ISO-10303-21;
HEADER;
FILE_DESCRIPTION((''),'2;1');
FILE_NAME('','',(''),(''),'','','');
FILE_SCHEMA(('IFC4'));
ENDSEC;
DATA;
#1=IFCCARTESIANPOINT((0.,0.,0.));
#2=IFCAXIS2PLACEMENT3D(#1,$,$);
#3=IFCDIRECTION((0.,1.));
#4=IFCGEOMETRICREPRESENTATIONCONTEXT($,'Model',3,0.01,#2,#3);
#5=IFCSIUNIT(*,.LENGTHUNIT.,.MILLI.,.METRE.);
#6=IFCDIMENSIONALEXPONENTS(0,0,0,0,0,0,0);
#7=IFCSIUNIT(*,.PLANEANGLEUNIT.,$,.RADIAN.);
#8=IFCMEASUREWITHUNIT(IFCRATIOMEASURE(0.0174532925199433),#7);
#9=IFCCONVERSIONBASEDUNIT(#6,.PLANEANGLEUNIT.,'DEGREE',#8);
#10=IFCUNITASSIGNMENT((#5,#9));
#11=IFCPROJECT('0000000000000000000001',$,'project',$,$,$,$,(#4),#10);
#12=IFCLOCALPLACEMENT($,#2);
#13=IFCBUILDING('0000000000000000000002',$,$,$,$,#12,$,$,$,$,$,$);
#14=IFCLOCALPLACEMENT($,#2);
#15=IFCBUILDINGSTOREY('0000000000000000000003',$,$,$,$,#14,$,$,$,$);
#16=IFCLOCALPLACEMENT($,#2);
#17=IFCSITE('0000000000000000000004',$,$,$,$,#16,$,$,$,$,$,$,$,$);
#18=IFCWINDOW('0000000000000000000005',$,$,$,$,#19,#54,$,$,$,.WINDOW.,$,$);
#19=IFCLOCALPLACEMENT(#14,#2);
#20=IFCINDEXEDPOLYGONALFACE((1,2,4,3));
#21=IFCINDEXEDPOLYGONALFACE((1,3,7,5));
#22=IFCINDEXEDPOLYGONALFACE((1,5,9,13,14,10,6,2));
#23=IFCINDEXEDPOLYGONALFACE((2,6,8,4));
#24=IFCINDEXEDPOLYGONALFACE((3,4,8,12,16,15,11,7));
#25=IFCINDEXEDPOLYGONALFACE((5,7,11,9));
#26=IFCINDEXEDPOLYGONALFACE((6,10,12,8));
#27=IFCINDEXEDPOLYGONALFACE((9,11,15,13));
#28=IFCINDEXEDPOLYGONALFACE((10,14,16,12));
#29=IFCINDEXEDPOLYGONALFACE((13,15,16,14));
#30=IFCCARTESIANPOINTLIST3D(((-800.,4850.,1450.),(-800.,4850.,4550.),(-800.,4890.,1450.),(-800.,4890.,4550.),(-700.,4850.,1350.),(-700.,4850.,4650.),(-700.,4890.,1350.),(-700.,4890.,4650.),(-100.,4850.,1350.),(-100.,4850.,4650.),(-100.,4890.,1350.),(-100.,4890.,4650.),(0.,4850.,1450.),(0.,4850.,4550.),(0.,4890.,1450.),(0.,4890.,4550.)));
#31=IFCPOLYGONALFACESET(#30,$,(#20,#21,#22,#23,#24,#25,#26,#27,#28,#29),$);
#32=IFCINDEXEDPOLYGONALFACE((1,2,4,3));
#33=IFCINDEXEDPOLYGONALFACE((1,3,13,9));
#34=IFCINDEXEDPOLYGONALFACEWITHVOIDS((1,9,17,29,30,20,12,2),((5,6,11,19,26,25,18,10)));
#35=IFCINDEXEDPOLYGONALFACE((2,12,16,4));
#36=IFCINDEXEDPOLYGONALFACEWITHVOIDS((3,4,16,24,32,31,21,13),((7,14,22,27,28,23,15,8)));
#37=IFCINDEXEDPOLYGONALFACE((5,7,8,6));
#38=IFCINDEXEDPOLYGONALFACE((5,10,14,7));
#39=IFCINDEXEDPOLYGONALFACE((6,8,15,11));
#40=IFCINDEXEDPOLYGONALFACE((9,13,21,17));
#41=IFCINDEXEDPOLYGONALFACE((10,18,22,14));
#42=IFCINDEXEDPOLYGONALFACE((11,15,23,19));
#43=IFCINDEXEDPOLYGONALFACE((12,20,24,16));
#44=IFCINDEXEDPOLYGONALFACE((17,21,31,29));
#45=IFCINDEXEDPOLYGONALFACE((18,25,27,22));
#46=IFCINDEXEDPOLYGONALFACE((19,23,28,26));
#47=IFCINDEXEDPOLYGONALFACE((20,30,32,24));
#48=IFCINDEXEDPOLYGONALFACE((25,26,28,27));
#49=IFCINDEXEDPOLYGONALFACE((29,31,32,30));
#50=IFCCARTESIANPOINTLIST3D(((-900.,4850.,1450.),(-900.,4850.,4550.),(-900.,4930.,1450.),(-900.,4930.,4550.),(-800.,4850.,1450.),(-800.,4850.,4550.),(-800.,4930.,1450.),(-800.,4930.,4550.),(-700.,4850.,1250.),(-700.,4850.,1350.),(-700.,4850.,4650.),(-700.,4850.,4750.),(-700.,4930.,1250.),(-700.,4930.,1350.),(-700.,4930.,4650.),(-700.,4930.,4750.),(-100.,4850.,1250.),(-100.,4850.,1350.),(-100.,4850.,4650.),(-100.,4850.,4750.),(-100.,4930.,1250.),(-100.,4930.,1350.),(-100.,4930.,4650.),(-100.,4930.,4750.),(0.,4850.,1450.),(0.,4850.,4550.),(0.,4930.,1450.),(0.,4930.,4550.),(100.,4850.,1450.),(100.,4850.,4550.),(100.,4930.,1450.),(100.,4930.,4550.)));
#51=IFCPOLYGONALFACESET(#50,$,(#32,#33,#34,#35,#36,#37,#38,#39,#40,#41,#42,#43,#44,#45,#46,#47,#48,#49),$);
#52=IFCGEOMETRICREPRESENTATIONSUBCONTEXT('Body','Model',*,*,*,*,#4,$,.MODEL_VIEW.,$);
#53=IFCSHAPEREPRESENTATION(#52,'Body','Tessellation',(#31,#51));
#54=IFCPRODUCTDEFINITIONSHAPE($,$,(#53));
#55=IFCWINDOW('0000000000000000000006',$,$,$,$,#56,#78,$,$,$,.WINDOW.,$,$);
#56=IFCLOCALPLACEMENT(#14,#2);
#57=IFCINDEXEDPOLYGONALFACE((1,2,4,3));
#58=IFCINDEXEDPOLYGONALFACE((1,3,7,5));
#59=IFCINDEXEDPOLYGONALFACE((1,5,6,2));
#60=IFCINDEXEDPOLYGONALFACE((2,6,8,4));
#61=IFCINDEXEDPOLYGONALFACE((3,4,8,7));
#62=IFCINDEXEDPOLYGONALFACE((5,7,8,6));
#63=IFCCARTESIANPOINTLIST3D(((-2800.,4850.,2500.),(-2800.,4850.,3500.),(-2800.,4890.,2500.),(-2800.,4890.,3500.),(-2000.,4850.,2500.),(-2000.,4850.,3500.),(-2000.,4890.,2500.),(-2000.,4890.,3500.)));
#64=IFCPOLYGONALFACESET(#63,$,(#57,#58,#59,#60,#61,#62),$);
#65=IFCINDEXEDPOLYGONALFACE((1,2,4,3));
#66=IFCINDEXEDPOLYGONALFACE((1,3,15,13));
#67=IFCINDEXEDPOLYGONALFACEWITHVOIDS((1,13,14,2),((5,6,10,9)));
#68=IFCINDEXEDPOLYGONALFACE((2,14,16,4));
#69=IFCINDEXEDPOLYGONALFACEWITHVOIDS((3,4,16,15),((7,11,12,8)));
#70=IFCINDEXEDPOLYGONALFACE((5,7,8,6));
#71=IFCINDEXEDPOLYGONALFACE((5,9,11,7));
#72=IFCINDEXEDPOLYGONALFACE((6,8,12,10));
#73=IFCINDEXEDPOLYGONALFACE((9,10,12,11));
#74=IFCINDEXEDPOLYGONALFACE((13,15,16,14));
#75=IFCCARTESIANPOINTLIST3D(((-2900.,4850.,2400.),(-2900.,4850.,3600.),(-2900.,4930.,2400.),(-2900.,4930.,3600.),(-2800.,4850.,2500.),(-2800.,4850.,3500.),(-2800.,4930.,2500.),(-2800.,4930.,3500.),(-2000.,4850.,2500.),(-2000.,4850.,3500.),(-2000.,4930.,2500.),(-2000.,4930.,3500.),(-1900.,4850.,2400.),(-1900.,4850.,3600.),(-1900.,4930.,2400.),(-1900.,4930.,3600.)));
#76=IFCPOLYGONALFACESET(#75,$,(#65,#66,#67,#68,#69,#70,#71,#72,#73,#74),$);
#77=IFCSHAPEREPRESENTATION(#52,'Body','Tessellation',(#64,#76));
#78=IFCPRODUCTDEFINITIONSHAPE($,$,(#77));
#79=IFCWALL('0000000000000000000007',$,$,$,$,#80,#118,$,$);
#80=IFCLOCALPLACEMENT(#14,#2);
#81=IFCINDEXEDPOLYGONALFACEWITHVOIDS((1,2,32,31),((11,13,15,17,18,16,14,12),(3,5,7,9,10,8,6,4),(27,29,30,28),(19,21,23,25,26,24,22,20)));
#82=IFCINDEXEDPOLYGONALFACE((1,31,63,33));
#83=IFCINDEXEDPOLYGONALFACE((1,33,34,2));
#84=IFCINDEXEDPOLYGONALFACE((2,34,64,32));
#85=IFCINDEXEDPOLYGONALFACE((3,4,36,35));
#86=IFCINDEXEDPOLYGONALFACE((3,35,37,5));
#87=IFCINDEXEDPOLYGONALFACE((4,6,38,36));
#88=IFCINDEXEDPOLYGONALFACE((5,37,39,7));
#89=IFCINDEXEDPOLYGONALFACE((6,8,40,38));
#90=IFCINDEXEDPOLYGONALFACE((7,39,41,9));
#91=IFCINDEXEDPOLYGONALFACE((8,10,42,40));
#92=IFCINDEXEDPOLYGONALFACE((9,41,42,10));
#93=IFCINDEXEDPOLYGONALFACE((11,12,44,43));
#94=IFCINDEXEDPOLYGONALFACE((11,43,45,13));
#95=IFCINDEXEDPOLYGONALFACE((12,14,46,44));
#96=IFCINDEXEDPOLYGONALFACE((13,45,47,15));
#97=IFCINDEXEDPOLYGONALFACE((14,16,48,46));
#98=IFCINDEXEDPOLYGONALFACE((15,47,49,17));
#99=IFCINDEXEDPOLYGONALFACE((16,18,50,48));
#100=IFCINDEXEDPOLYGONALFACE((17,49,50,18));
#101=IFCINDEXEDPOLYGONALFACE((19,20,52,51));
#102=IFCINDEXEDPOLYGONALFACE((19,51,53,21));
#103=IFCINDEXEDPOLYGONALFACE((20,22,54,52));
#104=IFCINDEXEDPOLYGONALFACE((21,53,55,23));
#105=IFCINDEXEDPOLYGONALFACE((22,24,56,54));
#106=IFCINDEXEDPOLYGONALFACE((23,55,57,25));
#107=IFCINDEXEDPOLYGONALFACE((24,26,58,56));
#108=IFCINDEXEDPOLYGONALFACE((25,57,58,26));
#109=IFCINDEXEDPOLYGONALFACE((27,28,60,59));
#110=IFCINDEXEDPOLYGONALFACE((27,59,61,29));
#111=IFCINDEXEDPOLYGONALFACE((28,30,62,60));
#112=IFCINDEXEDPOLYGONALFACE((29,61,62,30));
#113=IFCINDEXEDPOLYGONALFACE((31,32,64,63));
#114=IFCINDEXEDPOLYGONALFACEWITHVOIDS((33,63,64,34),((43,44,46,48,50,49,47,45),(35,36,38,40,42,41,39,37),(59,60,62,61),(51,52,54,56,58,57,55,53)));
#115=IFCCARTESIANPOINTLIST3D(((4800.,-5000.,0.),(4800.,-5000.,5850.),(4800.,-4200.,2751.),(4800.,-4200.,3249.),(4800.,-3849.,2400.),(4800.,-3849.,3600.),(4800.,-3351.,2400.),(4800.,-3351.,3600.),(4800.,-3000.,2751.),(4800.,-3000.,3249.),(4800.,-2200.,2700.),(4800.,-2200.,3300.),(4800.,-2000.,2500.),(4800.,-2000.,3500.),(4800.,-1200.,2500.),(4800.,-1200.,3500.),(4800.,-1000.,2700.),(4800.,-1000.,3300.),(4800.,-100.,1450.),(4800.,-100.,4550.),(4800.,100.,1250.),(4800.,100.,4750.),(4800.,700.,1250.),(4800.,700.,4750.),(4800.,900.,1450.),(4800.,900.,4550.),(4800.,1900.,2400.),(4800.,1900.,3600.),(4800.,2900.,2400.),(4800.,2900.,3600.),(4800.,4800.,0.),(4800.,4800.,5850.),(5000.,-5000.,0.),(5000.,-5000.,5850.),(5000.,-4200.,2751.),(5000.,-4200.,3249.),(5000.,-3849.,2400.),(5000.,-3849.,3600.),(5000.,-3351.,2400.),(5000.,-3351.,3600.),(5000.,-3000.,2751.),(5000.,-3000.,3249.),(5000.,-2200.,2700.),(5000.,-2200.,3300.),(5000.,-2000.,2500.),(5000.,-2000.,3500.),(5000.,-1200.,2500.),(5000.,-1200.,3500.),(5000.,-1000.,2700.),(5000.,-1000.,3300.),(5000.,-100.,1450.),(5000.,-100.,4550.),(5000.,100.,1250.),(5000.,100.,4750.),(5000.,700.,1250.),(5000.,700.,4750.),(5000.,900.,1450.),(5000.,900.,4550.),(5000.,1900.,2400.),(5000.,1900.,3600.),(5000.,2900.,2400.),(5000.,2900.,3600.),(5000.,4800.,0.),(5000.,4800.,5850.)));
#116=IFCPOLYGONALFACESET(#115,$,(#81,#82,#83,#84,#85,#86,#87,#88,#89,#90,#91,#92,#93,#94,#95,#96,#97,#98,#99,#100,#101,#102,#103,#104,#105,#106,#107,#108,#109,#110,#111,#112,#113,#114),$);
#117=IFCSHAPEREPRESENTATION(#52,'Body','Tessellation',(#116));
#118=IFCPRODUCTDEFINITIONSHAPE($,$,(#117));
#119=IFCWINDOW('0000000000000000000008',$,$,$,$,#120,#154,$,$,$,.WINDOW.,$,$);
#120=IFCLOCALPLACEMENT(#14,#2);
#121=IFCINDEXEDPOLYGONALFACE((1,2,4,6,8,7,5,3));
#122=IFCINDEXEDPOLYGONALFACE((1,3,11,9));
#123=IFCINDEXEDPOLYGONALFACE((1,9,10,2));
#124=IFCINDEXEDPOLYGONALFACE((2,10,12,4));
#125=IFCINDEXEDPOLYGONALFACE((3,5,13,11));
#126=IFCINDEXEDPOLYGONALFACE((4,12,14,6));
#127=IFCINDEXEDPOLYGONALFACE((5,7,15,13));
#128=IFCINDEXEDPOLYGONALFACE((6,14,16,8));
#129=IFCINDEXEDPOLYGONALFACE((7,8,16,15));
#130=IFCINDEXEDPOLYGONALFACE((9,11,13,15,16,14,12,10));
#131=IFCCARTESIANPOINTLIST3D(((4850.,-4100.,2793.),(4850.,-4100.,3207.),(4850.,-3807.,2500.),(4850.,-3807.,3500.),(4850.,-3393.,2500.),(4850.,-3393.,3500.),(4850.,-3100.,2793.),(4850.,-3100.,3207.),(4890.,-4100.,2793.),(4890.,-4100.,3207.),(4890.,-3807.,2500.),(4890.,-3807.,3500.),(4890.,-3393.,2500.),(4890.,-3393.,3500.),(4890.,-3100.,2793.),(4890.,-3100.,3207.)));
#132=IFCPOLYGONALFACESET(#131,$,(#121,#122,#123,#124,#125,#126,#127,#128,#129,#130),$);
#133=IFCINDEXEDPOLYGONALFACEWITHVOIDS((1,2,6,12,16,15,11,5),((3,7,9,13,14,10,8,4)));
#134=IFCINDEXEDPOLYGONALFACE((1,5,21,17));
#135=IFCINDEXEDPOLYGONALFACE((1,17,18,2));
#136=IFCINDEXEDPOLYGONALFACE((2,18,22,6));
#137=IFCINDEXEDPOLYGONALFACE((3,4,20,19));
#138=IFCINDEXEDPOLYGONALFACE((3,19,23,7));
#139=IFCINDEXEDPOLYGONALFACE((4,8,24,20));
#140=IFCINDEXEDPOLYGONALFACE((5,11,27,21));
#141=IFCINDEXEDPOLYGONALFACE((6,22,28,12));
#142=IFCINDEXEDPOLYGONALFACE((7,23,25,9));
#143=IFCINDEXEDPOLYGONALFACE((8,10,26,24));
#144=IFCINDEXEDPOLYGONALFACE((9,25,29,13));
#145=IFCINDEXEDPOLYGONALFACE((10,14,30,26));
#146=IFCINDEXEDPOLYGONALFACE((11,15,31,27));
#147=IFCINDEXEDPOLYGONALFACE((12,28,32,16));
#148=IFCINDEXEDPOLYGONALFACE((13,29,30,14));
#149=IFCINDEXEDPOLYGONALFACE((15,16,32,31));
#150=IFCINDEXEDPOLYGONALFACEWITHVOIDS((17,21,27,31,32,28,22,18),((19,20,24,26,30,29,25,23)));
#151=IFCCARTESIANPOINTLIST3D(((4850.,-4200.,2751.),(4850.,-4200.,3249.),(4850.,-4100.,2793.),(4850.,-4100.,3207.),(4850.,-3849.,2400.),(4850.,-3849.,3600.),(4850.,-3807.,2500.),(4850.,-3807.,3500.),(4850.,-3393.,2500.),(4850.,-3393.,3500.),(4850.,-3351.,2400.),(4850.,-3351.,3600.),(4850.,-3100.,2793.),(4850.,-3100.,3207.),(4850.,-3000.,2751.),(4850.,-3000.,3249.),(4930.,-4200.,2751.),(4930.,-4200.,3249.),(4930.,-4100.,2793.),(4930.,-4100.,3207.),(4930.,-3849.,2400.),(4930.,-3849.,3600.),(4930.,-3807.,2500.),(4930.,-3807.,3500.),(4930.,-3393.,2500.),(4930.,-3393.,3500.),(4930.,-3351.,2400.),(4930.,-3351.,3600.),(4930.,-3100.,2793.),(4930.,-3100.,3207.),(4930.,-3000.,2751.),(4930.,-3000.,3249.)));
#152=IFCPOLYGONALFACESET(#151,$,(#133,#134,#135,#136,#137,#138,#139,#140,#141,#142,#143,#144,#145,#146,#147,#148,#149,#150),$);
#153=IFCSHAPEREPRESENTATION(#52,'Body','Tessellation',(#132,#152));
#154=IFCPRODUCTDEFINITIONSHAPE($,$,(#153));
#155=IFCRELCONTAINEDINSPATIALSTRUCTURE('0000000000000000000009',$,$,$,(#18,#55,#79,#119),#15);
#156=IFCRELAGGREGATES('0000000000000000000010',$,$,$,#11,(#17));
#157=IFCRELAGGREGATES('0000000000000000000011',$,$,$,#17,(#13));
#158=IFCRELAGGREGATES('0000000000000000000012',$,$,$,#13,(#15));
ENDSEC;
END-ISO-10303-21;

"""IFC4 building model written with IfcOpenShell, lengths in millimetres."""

from ifc_helpers import new_model, entity, si_unit, converted_unit, direction, frame, origin, origin_2d, place, context, subcontext, project, spatial, polyline, rectangle, outline, extrude, element, save


model = new_model("IFC4")

# Units and contexts
model_context = context("Model", 3, precision=0.01, world=origin(), true_north=direction((0.0, 1.0)))
body_context = subcontext(model_context, "Body", "Model", "MODEL_VIEW")
ifc_project = project(units=[si_unit("LENGTHUNIT", "METRE", prefix="MILLI"), converted_unit("PLANEANGLEUNIT", "DEGREE", entity("IfcRatioMeasure", 0.0174532925199433), si_unit("PLANEANGLEUNIT", "RADIAN"), dimensions=[0, 0, 0, 0, 0, 0, 0])], contexts=[model_context])

# Site, building, storey
site_placement = place(None, origin())
site = spatial("IfcSite", under=ifc_project, at=site_placement)
building_placement = place(None, origin())
building = spatial("IfcBuilding", under=site, at=building_placement)
storey_placement = place(None, origin())
storey = spatial("IfcBuildingStorey", under=building, at=storey_placement)

# Shared definitions
wall_1_placement = place(storey_placement, frame((100.0, 4900.0, 0.0), z_axis=(0.0, 0.0, 1.0), x_axis=(-1.0, 0.0, 0.0)))
window_1_placement = place(wall_1_placement, frame((500.0, 50.0, 3000.0)))
window_2_placement = place(wall_1_placement, frame((2500.0, 50.0, 3000.0)))

# Windows
cartesian_point_1 = entity("IfcCartesianPoint", [-500.0, -207.0])
shared_polyline_1 = entity("IfcPolyline", [cartesian_point_1, entity("IfcCartesianPoint", [-500.0, 207.0]), entity("IfcCartesianPoint", [-207.0, 500.0]), entity("IfcCartesianPoint", [207.0, 500.0]), entity("IfcCartesianPoint", [500.0, 207.0]), entity("IfcCartesianPoint", [500.0, -207.0]), entity("IfcCartesianPoint", [207.0, -500.0]), entity("IfcCartesianPoint", [-207.0, -500.0]), cartesian_point_1])
cartesian_point_2 = entity("IfcCartesianPoint", [-400.0, -1550.0])
shared_polyline_2 = entity("IfcPolyline", [cartesian_point_2, entity("IfcCartesianPoint", [-400.0, 1550.0]), entity("IfcCartesianPoint", [-300.0, 1650.0]), entity("IfcCartesianPoint", [300.0, 1650.0]), entity("IfcCartesianPoint", [400.0, 1550.0]), entity("IfcCartesianPoint", [400.0, -1550.0]), entity("IfcCartesianPoint", [300.0, -1650.0]), entity("IfcCartesianPoint", [-300.0, -1650.0]), cartesian_point_2])
cartesian_point_3 = entity("IfcCartesianPoint", [-500.0, -1550.0])
element("IfcWindow", 1, at=window_1_placement, inside=storey, PredefinedType="WINDOW", context=body_context, shape_type="SweptSolid", body=[
    entity("IfcExtrudedAreaSolid", entity("IfcArbitraryClosedProfileDef", "AREA", None, shared_polyline_2), entity("IfcAxis2Placement3D", entity("IfcCartesianPoint", [0.0, 0.0, 0.0]), entity("IfcDirection", [0.0, -1.0, 0.0]), entity("IfcDirection", [1.0, 0.0, 0.0])), entity("IfcDirection", [0.0, 0.0, 1.0]), 40.0),
    entity("IfcExtrudedAreaSolid", entity("IfcArbitraryProfileDefWithVoids", "AREA", None, entity("IfcPolyline", [cartesian_point_3, entity("IfcCartesianPoint", [-500.0, 1550.0]), entity("IfcCartesianPoint", [-300.0, 1750.0]), entity("IfcCartesianPoint", [300.0, 1750.0]), entity("IfcCartesianPoint", [500.0, 1550.0]), entity("IfcCartesianPoint", [500.0, -1550.0]), entity("IfcCartesianPoint", [300.0, -1750.0]), entity("IfcCartesianPoint", [-300.0, -1750.0]), cartesian_point_3]), [shared_polyline_2]), entity("IfcAxis2Placement3D", entity("IfcCartesianPoint", [0.0, 0.0, 0.0]), entity("IfcDirection", [0.0, -1.0, 0.0]), entity("IfcDirection", [1.0, 0.0, 0.0])), entity("IfcDirection", [0.0, 0.0, 1.0]), 80.0),
])
cartesian_point_4 = entity("IfcCartesianPoint", [-400.0, -500.0])
shared_polyline_3 = entity("IfcPolyline", [cartesian_point_4, entity("IfcCartesianPoint", [-400.0, 500.0]), entity("IfcCartesianPoint", [-400.0, 500.0]), entity("IfcCartesianPoint", [400.0, 500.0]), entity("IfcCartesianPoint", [400.0, 500.0]), entity("IfcCartesianPoint", [400.0, -500.0]), entity("IfcCartesianPoint", [400.0, -500.0]), entity("IfcCartesianPoint", [-400.0, -500.0]), cartesian_point_4])
cartesian_point_5 = entity("IfcCartesianPoint", [-500.0, -600.0])
element("IfcWindow", 2, at=window_2_placement, inside=storey, PredefinedType="WINDOW", context=body_context, shape_type="SweptSolid", body=[
    entity("IfcExtrudedAreaSolid", entity("IfcArbitraryClosedProfileDef", "AREA", None, shared_polyline_3), entity("IfcAxis2Placement3D", entity("IfcCartesianPoint", [0.0, 0.0, 0.0]), entity("IfcDirection", [0.0, -1.0, 0.0]), entity("IfcDirection", [1.0, 0.0, 0.0])), entity("IfcDirection", [0.0, 0.0, 1.0]), 40.0),
    entity("IfcExtrudedAreaSolid", entity("IfcArbitraryProfileDefWithVoids", "AREA", None, entity("IfcPolyline", [cartesian_point_5, entity("IfcCartesianPoint", [-500.0, 600.0]), entity("IfcCartesianPoint", [-500.0, 600.0]), entity("IfcCartesianPoint", [500.0, 600.0]), entity("IfcCartesianPoint", [500.0, 600.0]), entity("IfcCartesianPoint", [500.0, -600.0]), entity("IfcCartesianPoint", [500.0, -600.0]), entity("IfcCartesianPoint", [-500.0, -600.0]), cartesian_point_5]), [shared_polyline_3]), entity("IfcAxis2Placement3D", entity("IfcCartesianPoint", [0.0, 0.0, 0.0]), entity("IfcDirection", [0.0, -1.0, 0.0]), entity("IfcDirection", [1.0, 0.0, 0.0])), entity("IfcDirection", [0.0, 0.0, 1.0]), 80.0),
])

# Wall, openings
wall_2_placement = place(storey_placement, frame((4900.0, -100.0, 0.0), z_axis=(0.0, 0.0, 1.0), x_axis=(0.0, 1.0, 0.0)))
wall_2 = element("IfcWall", 3, at=wall_2_placement, inside=storey, context=body_context, shape_type="SweptSolid", body=[
    extrude(rectangle(XDim=9800.0, YDim=200.0, at=origin_2d()), origin(), (0.0, 0.0, 1.0), 5850.0),
])
window_3_placement = place(wall_2_placement, frame((-3500.0, 50.0, 3000.0)))
opening_1_placement = place(window_3_placement, frame((0.0, 50.0, 0.0)))
element("IfcOpeningElement", 4, at=opening_1_placement, cuts=wall_2, context=body_context, shape_type="SweptSolid", body=[
    extrude(outline(polyline([(-600.0, -249.0), (-600.0, 249.0), (-249.0, 600.0), (249.0, 600.0), (600.0, 249.0), (600.0, -249.0), (249.0, -600.0), (-249.0, -600.0), (-600.0, -249.0)])), frame((0.0, 0.0, 0.0), z_axis=(0.0, -1.0, 0.0), x_axis=(1.0, 0.0, 0.0)), (0.0, 0.0, 1.0), 200.0),
])
window_4_placement = place(wall_2_placement, frame((-1500.0, 50.0, 3000.0)))
opening_2_placement = place(window_4_placement, frame((0.0, 50.0, 0.0)))
element("IfcOpeningElement", 5, at=opening_2_placement, cuts=wall_2, context=body_context, shape_type="SweptSolid", body=[
    extrude(outline(polyline([(-600.0, -300.0), (-600.0, 300.0), (-400.0, 500.0), (400.0, 500.0), (600.0, 300.0), (600.0, -300.0), (400.0, -500.0), (-400.0, -500.0), (-600.0, -300.0)])), frame((0.0, 0.0, 0.0), z_axis=(0.0, -1.0, 0.0), x_axis=(1.0, 0.0, 0.0)), (0.0, 0.0, 1.0), 200.0),
])
window_5_placement = place(wall_2_placement, frame((500.0, 50.0, 3000.0)))
opening_3_placement = place(window_5_placement, frame((0.0, 50.0, 0.0)))
element("IfcOpeningElement", 6, at=opening_3_placement, cuts=wall_2, context=body_context, shape_type="SweptSolid", body=[
    extrude(outline(polyline([(-500.0, -1550.0), (-500.0, 1550.0), (-300.0, 1750.0), (300.0, 1750.0), (500.0, 1550.0), (500.0, -1550.0), (300.0, -1750.0), (-300.0, -1750.0), (-500.0, -1550.0)])), frame((0.0, 0.0, 0.0), z_axis=(0.0, -1.0, 0.0), x_axis=(1.0, 0.0, 0.0)), (0.0, 0.0, 1.0), 200.0),
])
window_6_placement = place(wall_2_placement, frame((2500.0, 50.0, 3000.0)))
opening_4_placement = place(window_6_placement, frame((0.0, 50.0, 0.0)))
element("IfcOpeningElement", 7, at=opening_4_placement, cuts=wall_2, context=body_context, shape_type="SweptSolid", body=[
    extrude(outline(polyline([(-500.0, -600.0), (-500.0, 600.0), (-500.0, 600.0), (500.0, 600.0), (500.0, 600.0), (500.0, -600.0), (500.0, -600.0), (-500.0, -600.0), (-500.0, -600.0)])), frame((0.0, 0.0, 0.0), z_axis=(0.0, -1.0, 0.0), x_axis=(1.0, 0.0, 0.0)), (0.0, 0.0, 1.0), 200.0),
])

# Window
cartesian_point_6 = entity("IfcCartesianPoint", [-600.0, -249.0])
element("IfcWindow", 8, at=window_3_placement, inside=storey, PredefinedType="WINDOW", context=body_context, shape_type="SweptSolid", body=[
    entity("IfcExtrudedAreaSolid", entity("IfcArbitraryClosedProfileDef", "AREA", None, shared_polyline_1), entity("IfcAxis2Placement3D", entity("IfcCartesianPoint", [0.0, 0.0, 0.0]), entity("IfcDirection", [0.0, -1.0, 0.0]), entity("IfcDirection", [1.0, 0.0, 0.0])), entity("IfcDirection", [0.0, 0.0, 1.0]), 40.0),
    entity("IfcExtrudedAreaSolid", entity("IfcArbitraryProfileDefWithVoids", "AREA", None, entity("IfcPolyline", [cartesian_point_6, entity("IfcCartesianPoint", [-600.0, 249.0]), entity("IfcCartesianPoint", [-249.0, 600.0]), entity("IfcCartesianPoint", [249.0, 600.0]), entity("IfcCartesianPoint", [600.0, 249.0]), entity("IfcCartesianPoint", [600.0, -249.0]), entity("IfcCartesianPoint", [249.0, -600.0]), entity("IfcCartesianPoint", [-249.0, -600.0]), cartesian_point_6]), [shared_polyline_1]), entity("IfcAxis2Placement3D", entity("IfcCartesianPoint", [0.0, 0.0, 0.0]), entity("IfcDirection", [0.0, -1.0, 0.0]), entity("IfcDirection", [1.0, 0.0, 0.0])), entity("IfcDirection", [0.0, 0.0, 1.0]), 80.0),
])

save(model, "model.ifc")
